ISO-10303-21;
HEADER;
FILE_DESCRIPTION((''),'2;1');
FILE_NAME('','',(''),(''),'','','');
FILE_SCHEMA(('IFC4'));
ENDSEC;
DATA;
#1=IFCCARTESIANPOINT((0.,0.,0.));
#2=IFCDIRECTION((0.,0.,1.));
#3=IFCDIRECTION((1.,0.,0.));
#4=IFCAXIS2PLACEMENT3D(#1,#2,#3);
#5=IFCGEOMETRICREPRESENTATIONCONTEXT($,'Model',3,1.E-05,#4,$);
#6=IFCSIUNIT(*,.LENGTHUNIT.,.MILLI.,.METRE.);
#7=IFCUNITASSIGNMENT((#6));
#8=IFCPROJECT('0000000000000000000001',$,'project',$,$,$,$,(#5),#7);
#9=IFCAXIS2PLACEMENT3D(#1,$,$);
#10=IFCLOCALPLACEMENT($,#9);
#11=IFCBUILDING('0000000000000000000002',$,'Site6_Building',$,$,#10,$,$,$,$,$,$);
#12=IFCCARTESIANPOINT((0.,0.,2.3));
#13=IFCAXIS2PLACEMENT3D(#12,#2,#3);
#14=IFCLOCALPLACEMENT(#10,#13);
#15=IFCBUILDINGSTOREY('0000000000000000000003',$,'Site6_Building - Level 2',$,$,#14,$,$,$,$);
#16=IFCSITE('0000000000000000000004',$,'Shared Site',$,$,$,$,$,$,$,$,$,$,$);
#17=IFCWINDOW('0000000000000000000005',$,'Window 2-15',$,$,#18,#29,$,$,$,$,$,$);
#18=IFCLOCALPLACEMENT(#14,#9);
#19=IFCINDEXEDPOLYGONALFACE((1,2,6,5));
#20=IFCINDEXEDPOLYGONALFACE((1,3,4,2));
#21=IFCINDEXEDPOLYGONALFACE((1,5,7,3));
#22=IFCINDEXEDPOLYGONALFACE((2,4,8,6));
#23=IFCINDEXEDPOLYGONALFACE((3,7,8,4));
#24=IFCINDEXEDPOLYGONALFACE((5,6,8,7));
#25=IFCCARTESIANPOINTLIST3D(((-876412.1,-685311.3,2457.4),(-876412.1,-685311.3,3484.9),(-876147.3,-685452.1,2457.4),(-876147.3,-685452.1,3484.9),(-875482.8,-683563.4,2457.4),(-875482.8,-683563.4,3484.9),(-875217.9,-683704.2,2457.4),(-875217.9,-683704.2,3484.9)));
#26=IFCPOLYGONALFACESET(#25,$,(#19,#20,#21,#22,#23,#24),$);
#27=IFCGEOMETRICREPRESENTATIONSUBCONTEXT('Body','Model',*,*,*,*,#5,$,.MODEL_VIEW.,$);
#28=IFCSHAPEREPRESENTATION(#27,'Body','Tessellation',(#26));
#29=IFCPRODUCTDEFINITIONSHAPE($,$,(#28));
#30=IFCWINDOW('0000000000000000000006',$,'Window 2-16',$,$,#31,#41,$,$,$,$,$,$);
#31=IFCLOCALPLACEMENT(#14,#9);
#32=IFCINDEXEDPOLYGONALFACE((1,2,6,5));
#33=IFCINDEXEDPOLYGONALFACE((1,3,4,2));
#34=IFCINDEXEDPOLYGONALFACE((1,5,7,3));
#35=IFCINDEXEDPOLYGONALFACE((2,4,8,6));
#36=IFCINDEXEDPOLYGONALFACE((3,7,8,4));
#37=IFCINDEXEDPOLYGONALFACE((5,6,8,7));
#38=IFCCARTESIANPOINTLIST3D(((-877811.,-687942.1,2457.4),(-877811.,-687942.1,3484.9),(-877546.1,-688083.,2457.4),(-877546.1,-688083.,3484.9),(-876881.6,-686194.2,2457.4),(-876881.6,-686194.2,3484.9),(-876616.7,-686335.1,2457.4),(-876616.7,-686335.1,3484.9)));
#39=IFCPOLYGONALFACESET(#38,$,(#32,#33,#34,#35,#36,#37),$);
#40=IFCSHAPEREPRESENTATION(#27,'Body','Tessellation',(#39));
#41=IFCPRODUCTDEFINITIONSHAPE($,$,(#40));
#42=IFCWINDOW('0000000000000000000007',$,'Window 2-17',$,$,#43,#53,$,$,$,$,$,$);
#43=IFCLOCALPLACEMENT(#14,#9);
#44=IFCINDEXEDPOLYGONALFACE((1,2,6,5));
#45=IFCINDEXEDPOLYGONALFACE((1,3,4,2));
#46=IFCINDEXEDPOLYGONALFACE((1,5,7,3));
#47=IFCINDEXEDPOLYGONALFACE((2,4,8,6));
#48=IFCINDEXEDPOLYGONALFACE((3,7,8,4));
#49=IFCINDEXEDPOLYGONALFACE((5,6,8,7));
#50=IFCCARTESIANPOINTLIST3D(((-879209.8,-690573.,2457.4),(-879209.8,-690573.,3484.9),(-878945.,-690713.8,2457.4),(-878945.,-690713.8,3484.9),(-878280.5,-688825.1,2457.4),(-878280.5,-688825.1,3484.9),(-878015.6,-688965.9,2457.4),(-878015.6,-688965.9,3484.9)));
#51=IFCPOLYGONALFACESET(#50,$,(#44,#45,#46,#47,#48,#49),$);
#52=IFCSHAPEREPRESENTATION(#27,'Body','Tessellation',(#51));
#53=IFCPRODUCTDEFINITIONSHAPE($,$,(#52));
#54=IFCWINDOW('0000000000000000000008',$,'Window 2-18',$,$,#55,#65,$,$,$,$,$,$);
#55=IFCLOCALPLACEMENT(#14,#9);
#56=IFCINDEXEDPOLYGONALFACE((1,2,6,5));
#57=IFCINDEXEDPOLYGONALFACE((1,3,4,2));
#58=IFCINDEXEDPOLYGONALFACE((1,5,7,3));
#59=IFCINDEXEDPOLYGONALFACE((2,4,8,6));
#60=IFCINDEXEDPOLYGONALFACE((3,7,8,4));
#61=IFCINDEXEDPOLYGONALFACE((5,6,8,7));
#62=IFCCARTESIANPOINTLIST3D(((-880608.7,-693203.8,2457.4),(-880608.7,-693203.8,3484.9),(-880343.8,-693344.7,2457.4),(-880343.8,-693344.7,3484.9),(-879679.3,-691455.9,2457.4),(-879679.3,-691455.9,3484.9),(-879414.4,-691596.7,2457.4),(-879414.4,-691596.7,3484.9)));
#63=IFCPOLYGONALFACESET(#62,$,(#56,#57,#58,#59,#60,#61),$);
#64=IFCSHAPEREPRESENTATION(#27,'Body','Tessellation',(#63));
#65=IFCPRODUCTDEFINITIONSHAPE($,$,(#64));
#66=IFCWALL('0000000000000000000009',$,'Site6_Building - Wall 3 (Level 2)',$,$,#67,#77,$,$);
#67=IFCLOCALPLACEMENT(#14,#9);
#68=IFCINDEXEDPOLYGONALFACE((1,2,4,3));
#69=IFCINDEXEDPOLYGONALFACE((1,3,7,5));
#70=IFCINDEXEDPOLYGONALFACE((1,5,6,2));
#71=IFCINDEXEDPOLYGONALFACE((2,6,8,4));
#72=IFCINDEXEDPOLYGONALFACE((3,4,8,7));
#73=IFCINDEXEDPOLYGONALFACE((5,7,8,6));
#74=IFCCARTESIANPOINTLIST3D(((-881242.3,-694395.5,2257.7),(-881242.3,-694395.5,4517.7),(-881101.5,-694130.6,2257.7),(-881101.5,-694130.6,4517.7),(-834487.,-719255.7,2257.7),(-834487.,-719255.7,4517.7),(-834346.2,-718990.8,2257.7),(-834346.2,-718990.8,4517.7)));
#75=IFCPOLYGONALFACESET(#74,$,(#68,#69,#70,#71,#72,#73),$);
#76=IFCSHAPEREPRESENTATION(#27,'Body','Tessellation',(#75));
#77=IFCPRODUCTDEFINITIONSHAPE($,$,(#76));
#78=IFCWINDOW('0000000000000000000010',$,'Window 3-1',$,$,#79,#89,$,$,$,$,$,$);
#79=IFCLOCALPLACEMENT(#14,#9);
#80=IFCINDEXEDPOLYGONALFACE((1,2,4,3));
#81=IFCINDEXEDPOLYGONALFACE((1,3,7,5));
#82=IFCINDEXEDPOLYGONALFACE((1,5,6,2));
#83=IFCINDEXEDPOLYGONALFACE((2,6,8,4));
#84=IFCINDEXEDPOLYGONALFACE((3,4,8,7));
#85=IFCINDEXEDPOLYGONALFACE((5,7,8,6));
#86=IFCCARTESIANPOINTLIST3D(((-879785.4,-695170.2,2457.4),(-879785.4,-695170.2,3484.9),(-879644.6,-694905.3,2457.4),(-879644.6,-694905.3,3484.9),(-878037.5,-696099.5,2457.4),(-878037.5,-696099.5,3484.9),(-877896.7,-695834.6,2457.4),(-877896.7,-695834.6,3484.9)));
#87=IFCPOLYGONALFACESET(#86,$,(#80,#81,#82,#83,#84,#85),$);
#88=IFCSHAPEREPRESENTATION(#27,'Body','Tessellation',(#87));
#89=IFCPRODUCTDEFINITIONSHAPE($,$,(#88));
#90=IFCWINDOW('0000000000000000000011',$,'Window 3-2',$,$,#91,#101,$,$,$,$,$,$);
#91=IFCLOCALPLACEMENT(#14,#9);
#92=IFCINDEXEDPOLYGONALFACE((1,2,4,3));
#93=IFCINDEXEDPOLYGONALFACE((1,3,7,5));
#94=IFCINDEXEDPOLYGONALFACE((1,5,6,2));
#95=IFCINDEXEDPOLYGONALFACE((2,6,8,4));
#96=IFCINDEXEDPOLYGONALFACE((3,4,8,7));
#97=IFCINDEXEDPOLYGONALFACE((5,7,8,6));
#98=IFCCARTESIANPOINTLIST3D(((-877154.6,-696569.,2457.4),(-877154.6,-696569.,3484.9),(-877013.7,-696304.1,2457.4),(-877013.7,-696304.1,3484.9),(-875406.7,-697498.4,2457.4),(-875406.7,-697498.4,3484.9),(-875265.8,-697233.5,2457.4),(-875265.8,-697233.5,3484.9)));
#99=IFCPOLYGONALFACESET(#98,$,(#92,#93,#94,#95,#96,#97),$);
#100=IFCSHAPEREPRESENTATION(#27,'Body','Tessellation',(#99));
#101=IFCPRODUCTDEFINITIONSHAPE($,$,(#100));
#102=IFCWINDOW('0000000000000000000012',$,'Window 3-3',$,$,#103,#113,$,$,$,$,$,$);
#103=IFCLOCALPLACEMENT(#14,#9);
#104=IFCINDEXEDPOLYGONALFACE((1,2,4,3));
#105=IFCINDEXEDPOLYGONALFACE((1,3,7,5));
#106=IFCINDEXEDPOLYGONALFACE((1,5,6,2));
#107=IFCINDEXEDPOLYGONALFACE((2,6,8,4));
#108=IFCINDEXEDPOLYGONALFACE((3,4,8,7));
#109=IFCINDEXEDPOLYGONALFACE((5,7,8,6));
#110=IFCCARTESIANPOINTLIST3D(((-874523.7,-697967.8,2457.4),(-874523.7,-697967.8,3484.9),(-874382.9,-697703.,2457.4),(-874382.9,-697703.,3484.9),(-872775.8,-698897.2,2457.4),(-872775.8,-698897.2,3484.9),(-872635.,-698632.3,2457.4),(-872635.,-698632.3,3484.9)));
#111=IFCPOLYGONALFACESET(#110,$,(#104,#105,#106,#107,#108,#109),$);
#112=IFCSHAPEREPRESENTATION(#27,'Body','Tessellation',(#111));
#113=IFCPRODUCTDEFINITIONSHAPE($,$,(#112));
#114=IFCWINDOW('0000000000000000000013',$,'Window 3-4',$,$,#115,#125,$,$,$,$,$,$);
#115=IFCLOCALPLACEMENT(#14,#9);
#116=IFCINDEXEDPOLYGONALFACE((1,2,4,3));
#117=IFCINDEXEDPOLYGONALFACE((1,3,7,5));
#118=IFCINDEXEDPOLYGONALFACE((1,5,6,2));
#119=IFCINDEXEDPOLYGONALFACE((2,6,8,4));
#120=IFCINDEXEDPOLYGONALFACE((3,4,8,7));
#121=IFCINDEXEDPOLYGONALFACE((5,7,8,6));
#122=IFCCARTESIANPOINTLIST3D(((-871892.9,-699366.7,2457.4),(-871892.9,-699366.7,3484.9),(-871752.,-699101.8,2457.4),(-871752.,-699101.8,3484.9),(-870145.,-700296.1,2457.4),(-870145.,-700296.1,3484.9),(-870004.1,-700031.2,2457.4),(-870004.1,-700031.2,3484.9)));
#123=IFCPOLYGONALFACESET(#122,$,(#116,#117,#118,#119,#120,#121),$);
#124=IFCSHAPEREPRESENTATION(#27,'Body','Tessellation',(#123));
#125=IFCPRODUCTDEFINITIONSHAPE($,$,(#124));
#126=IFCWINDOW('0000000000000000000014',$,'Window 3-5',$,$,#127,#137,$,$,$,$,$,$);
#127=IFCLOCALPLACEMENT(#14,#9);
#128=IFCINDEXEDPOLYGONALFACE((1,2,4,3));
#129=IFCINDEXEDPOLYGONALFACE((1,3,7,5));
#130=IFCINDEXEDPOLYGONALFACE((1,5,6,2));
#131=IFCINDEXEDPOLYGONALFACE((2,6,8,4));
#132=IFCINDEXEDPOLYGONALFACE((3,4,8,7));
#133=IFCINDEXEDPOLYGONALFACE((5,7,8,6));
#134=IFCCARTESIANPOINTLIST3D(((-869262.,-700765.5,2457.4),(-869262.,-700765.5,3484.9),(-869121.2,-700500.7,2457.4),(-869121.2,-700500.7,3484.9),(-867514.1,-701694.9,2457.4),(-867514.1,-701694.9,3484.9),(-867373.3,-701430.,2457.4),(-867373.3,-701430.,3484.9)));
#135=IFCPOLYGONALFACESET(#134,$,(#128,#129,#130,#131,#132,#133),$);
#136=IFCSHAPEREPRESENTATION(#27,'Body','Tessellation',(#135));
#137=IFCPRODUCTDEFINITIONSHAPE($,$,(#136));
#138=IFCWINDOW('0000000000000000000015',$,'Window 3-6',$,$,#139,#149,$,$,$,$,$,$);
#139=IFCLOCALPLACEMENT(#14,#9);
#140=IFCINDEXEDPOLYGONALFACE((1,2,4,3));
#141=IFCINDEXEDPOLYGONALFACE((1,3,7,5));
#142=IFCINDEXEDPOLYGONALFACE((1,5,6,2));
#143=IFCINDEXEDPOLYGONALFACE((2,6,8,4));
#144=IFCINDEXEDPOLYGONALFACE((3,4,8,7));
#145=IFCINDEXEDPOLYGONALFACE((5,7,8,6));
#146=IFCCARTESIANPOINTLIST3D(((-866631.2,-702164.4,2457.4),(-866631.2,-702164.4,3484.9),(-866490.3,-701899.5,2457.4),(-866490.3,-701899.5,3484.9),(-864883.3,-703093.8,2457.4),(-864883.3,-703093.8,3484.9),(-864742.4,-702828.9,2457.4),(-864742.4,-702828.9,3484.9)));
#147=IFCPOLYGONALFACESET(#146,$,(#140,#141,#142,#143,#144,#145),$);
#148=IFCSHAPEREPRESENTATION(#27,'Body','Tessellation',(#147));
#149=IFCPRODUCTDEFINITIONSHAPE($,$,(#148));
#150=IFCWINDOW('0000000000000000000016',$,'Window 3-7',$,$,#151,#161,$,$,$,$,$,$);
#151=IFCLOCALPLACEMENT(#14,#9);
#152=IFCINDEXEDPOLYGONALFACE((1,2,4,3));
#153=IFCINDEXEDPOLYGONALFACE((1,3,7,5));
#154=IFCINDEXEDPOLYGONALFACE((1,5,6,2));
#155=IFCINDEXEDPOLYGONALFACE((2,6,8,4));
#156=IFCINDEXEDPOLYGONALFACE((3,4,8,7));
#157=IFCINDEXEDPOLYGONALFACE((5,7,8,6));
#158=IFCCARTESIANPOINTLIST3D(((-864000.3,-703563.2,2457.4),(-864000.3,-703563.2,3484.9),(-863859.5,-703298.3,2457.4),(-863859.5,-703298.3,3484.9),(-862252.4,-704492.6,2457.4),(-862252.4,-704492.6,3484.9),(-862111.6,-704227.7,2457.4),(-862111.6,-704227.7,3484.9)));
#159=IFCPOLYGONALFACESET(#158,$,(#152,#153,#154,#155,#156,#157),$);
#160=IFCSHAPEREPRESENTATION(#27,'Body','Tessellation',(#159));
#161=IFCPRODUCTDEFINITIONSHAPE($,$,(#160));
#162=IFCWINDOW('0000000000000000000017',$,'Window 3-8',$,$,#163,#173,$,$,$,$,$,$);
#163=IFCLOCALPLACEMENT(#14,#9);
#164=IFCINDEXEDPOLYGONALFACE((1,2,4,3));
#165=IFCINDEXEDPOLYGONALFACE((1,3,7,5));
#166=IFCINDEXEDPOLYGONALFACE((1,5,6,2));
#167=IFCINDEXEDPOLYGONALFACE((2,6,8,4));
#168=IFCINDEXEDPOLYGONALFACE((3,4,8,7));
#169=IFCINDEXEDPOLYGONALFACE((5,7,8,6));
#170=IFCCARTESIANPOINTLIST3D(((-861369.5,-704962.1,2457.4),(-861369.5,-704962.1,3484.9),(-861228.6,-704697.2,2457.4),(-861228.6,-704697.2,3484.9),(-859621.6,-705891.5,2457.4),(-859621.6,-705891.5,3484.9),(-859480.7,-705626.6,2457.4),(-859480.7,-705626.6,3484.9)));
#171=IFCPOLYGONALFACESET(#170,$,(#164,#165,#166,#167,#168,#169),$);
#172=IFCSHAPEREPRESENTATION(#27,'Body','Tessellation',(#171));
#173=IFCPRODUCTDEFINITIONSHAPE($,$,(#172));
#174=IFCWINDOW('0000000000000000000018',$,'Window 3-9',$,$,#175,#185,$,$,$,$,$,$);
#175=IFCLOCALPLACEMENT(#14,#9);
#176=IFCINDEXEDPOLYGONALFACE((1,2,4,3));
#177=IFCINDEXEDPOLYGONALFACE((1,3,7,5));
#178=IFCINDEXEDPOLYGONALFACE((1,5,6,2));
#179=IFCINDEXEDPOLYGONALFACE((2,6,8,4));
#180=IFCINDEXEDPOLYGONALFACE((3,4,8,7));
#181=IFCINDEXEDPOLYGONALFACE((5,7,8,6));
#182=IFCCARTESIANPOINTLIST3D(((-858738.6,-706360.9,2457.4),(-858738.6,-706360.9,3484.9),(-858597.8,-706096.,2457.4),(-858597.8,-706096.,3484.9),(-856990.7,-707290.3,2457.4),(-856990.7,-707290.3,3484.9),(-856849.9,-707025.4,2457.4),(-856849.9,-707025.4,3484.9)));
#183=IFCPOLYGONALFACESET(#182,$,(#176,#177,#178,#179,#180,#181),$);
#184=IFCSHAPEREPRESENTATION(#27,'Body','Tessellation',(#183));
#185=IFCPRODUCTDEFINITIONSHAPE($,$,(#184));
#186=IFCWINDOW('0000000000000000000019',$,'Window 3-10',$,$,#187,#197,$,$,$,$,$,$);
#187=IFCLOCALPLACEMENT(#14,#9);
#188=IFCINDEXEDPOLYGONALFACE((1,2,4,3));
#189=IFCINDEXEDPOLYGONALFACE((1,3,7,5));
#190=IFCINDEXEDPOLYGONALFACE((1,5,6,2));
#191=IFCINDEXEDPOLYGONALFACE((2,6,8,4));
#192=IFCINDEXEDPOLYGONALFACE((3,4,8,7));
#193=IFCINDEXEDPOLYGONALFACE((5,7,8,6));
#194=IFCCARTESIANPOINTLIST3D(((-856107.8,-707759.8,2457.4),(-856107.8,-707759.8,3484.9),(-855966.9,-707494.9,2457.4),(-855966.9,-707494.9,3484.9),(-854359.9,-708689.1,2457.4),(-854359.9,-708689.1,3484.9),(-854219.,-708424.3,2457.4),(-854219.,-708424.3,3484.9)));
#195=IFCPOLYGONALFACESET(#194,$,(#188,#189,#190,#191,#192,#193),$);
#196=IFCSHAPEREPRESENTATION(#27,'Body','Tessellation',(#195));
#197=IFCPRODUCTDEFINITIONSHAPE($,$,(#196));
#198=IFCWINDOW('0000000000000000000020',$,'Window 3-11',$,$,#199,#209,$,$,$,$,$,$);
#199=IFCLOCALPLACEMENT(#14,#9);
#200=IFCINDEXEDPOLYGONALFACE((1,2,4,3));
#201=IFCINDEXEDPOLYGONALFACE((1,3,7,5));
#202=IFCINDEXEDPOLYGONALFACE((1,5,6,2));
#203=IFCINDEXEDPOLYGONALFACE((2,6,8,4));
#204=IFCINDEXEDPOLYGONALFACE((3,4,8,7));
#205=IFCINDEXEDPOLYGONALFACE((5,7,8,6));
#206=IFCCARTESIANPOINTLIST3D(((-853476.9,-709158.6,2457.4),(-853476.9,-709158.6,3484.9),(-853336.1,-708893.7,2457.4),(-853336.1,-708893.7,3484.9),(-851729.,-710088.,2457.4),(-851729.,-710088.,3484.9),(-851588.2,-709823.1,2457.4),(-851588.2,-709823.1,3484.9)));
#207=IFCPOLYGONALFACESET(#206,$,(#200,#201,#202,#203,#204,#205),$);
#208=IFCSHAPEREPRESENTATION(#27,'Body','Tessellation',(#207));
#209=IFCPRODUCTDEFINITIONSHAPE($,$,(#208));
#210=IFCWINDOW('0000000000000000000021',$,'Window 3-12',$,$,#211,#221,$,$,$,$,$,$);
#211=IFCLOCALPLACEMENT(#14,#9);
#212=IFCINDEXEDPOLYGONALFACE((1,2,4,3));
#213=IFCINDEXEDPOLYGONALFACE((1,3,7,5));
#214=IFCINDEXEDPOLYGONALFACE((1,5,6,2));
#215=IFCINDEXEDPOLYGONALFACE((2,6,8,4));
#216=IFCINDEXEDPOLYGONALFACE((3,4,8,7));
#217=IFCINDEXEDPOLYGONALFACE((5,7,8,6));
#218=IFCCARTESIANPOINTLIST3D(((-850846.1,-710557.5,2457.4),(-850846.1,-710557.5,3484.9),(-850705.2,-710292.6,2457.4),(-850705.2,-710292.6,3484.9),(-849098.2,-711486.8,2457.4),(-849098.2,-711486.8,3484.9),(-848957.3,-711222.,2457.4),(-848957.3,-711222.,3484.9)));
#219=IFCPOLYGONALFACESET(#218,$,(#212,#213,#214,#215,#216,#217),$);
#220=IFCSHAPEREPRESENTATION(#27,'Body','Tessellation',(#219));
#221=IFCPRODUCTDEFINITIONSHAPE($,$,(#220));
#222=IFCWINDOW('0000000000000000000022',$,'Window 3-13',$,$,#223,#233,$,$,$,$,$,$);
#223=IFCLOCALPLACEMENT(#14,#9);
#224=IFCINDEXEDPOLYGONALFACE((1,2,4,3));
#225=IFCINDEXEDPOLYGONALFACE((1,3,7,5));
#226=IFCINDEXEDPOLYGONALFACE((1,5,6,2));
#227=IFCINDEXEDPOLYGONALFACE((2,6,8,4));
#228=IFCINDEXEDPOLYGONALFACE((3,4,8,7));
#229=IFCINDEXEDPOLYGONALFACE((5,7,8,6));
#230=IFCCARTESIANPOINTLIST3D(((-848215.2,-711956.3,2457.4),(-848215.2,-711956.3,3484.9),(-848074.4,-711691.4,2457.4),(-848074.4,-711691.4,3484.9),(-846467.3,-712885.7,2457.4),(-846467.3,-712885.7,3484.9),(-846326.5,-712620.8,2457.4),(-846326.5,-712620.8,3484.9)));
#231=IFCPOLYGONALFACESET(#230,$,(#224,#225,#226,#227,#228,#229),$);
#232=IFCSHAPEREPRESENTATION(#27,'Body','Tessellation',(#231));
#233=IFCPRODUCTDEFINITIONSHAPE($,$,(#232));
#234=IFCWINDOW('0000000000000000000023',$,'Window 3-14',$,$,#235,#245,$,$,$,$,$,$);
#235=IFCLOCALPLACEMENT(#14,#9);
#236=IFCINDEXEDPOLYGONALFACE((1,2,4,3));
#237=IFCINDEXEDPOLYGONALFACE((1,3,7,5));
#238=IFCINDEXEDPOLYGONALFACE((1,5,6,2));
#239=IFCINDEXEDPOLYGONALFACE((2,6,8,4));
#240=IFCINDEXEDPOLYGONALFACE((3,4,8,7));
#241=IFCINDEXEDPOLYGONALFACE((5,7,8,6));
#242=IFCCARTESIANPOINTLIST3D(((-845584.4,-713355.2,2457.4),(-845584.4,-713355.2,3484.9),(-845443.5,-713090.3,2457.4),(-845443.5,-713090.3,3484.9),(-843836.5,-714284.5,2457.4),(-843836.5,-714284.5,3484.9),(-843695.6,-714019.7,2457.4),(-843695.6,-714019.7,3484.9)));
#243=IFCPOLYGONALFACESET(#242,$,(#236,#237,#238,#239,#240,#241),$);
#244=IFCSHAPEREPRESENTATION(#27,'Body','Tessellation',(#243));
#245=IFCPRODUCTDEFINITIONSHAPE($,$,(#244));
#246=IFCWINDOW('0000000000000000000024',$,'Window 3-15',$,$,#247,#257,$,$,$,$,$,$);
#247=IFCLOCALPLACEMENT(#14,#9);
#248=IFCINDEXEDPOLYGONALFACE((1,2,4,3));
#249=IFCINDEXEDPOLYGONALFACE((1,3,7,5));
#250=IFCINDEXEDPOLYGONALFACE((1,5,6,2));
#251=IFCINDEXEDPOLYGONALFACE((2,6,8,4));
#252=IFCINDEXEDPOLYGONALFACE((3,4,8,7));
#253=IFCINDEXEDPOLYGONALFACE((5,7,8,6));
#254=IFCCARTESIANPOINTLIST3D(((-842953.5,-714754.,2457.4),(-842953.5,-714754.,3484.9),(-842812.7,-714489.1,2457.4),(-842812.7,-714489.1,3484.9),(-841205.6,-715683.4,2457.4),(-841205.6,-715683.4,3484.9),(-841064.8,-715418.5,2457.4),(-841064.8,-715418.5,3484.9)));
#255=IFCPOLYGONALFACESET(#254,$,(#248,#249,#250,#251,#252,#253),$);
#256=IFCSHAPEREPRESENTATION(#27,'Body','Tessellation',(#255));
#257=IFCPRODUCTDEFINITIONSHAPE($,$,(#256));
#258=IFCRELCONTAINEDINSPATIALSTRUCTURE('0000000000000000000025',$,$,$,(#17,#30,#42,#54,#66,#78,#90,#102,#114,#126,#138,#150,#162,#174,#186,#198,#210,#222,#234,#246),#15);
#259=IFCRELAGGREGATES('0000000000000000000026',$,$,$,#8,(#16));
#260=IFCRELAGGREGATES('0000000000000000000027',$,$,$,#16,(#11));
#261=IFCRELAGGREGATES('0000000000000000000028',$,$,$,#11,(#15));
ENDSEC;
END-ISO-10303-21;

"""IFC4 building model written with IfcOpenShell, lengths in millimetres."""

from ifc_helpers import new_model, si_unit, frame, origin, origin_with_axes, place, context, subcontext, project, spatial, indexed_curve, outline, extrude, element, save


model = new_model("IFC4")

# Units and contexts
model_context = context("Model", 3, precision=1e-05, world=origin_with_axes())
body_context = subcontext(model_context, "Body", "Model", "MODEL_VIEW")
ifc_project = project(units=[si_unit("LENGTHUNIT", "METRE", prefix="MILLI")], contexts=[model_context])

# Site, building, storey
site = spatial("IfcSite", under=ifc_project, Name="Shared Site")
building_placement = place(None, origin())
building = spatial("IfcBuilding", under=site, at=building_placement, Name="Site6_Building")
storey_placement = place(building_placement, frame((0.0, 0.0, 2.3), z_axis=(0.0, 0.0, 1.0), x_axis=(1.0, 0.0, 0.0)))
storey = spatial("IfcBuildingStorey", under=building, at=storey_placement, Name="Site6_Building - Level 2")

# Windows
for number, where, z_axis, x_axis, name in (
    (1, (-875482.8, -683563.4, 2457.4), (0.0, 0.0, 1.0), (-0.469472, -0.882948, 0.0), "Window 2-15"),
    (2, (-876881.6, -686194.2, 2457.4), (0.0, 0.0, 1.0), (-0.469472, -0.882948, 0.0), "Window 2-16"),
    (3, (-878280.5, -688825.1, 2457.4), (0.0, 0.0, 1.0), (-0.469472, -0.882948, 0.0), "Window 2-17"),
    (4, (-879679.3, -691455.9, 2457.4), (0.0, 0.0, 1.0), (-0.469472, -0.882948, 0.0), "Window 2-18"),
):
    element("IfcWindow", number, at=place(storey_placement, frame(where, z_axis=z_axis, x_axis=x_axis)), inside=storey, Name=name, context=body_context, shape_type="SweptSolid", body=[
        extrude(outline(indexed_curve([(0.0, 0.0), (0.0, 300.0), (1979.6, 300.0), (1979.6, 0.0), (0.0, 0.0)], self_intersect=False)), origin_with_axes(), (0.0, 0.0, 1.0), 1027.5),
    ])

# Wall
wall_1_placement = place(storey_placement, frame((-881242.3, -694395.5, 2257.7), z_axis=(0.0, 0.0, 1.0), x_axis=(0.882948, -0.469472, 0.0)))
element("IfcWall", 5, at=wall_1_placement, inside=storey, Name="Site6_Building - Wall 3 (Level 2)", context=body_context, shape_type="SweptSolid", body=[
    extrude(outline(indexed_curve([(0.0, 0.0), (0.0, 300.0), (52953.6, 300.0), (52953.6, 0.0), (0.0, 0.0)], self_intersect=False)), origin_with_axes(), (0.0, 0.0, 1.0), 2260.0),
])

# Windows
for number, where, z_axis, x_axis, name in (
    (6, (-879785.4, -695170.2, 2457.4), (0.0, 0.0, 1.0), (0.882948, -0.469472, 0.0), "Window 3-1"),
    (7, (-877154.6, -696569.0, 2457.4), (0.0, 0.0, 1.0), (0.882948, -0.469472, 0.0), "Window 3-2"),
    (8, (-874523.7, -697967.8, 2457.4), (0.0, 0.0, 1.0), (0.882948, -0.469472, 0.0), "Window 3-3"),
    (9, (-871892.9, -699366.7, 2457.4), (0.0, 0.0, 1.0), (0.882948, -0.469472, 0.0), "Window 3-4"),
    (10, (-869262.0, -700765.5, 2457.4), (0.0, 0.0, 1.0), (0.882948, -0.469472, 0.0), "Window 3-5"),
    (11, (-866631.2, -702164.4, 2457.4), (0.0, 0.0, 1.0), (0.882948, -0.469472, 0.0), "Window 3-6"),
    (12, (-864000.3, -703563.2, 2457.4), (0.0, 0.0, 1.0), (0.882948, -0.469472, 0.0), "Window 3-7"),
    (13, (-861369.5, -704962.1, 2457.4), (0.0, 0.0, 1.0), (0.882948, -0.469472, 0.0), "Window 3-8"),
    (14, (-858738.6, -706360.9, 2457.4), (0.0, 0.0, 1.0), (0.882948, -0.469472, 0.0), "Window 3-9"),
    (15, (-856107.8, -707759.8, 2457.4), (0.0, 0.0, 1.0), (0.882948, -0.469472, 0.0), "Window 3-10"),
    (16, (-853476.9, -709158.6, 2457.4), (0.0, 0.0, 1.0), (0.882948, -0.469472, 0.0), "Window 3-11"),
    (17, (-850846.1, -710557.5, 2457.4), (0.0, 0.0, 1.0), (0.882948, -0.469472, 0.0), "Window 3-12"),
    (18, (-848215.2, -711956.3, 2457.4), (0.0, 0.0, 1.0), (0.882948, -0.469472, 0.0), "Window 3-13"),
    (19, (-845584.4, -713355.2, 2457.4), (0.0, 0.0, 1.0), (0.882948, -0.469472, 0.0), "Window 3-14"),
    (20, (-842953.5, -714754.0, 2457.4), (0.0, 0.0, 1.0), (0.882948, -0.469472, 0.0), "Window 3-15"),
):
    element("IfcWindow", number, at=place(storey_placement, frame(where, z_axis=z_axis, x_axis=x_axis)), inside=storey, Name=name, context=body_context, shape_type="SweptSolid", body=[
        extrude(outline(indexed_curve([(0.0, 0.0), (0.0, 300.0), (1979.6, 300.0), (1979.6, 0.0), (0.0, 0.0)], self_intersect=False)), origin_with_axes(), (0.0, 0.0, 1.0), 1027.5),
    ])

save(model, "model.ifc")
